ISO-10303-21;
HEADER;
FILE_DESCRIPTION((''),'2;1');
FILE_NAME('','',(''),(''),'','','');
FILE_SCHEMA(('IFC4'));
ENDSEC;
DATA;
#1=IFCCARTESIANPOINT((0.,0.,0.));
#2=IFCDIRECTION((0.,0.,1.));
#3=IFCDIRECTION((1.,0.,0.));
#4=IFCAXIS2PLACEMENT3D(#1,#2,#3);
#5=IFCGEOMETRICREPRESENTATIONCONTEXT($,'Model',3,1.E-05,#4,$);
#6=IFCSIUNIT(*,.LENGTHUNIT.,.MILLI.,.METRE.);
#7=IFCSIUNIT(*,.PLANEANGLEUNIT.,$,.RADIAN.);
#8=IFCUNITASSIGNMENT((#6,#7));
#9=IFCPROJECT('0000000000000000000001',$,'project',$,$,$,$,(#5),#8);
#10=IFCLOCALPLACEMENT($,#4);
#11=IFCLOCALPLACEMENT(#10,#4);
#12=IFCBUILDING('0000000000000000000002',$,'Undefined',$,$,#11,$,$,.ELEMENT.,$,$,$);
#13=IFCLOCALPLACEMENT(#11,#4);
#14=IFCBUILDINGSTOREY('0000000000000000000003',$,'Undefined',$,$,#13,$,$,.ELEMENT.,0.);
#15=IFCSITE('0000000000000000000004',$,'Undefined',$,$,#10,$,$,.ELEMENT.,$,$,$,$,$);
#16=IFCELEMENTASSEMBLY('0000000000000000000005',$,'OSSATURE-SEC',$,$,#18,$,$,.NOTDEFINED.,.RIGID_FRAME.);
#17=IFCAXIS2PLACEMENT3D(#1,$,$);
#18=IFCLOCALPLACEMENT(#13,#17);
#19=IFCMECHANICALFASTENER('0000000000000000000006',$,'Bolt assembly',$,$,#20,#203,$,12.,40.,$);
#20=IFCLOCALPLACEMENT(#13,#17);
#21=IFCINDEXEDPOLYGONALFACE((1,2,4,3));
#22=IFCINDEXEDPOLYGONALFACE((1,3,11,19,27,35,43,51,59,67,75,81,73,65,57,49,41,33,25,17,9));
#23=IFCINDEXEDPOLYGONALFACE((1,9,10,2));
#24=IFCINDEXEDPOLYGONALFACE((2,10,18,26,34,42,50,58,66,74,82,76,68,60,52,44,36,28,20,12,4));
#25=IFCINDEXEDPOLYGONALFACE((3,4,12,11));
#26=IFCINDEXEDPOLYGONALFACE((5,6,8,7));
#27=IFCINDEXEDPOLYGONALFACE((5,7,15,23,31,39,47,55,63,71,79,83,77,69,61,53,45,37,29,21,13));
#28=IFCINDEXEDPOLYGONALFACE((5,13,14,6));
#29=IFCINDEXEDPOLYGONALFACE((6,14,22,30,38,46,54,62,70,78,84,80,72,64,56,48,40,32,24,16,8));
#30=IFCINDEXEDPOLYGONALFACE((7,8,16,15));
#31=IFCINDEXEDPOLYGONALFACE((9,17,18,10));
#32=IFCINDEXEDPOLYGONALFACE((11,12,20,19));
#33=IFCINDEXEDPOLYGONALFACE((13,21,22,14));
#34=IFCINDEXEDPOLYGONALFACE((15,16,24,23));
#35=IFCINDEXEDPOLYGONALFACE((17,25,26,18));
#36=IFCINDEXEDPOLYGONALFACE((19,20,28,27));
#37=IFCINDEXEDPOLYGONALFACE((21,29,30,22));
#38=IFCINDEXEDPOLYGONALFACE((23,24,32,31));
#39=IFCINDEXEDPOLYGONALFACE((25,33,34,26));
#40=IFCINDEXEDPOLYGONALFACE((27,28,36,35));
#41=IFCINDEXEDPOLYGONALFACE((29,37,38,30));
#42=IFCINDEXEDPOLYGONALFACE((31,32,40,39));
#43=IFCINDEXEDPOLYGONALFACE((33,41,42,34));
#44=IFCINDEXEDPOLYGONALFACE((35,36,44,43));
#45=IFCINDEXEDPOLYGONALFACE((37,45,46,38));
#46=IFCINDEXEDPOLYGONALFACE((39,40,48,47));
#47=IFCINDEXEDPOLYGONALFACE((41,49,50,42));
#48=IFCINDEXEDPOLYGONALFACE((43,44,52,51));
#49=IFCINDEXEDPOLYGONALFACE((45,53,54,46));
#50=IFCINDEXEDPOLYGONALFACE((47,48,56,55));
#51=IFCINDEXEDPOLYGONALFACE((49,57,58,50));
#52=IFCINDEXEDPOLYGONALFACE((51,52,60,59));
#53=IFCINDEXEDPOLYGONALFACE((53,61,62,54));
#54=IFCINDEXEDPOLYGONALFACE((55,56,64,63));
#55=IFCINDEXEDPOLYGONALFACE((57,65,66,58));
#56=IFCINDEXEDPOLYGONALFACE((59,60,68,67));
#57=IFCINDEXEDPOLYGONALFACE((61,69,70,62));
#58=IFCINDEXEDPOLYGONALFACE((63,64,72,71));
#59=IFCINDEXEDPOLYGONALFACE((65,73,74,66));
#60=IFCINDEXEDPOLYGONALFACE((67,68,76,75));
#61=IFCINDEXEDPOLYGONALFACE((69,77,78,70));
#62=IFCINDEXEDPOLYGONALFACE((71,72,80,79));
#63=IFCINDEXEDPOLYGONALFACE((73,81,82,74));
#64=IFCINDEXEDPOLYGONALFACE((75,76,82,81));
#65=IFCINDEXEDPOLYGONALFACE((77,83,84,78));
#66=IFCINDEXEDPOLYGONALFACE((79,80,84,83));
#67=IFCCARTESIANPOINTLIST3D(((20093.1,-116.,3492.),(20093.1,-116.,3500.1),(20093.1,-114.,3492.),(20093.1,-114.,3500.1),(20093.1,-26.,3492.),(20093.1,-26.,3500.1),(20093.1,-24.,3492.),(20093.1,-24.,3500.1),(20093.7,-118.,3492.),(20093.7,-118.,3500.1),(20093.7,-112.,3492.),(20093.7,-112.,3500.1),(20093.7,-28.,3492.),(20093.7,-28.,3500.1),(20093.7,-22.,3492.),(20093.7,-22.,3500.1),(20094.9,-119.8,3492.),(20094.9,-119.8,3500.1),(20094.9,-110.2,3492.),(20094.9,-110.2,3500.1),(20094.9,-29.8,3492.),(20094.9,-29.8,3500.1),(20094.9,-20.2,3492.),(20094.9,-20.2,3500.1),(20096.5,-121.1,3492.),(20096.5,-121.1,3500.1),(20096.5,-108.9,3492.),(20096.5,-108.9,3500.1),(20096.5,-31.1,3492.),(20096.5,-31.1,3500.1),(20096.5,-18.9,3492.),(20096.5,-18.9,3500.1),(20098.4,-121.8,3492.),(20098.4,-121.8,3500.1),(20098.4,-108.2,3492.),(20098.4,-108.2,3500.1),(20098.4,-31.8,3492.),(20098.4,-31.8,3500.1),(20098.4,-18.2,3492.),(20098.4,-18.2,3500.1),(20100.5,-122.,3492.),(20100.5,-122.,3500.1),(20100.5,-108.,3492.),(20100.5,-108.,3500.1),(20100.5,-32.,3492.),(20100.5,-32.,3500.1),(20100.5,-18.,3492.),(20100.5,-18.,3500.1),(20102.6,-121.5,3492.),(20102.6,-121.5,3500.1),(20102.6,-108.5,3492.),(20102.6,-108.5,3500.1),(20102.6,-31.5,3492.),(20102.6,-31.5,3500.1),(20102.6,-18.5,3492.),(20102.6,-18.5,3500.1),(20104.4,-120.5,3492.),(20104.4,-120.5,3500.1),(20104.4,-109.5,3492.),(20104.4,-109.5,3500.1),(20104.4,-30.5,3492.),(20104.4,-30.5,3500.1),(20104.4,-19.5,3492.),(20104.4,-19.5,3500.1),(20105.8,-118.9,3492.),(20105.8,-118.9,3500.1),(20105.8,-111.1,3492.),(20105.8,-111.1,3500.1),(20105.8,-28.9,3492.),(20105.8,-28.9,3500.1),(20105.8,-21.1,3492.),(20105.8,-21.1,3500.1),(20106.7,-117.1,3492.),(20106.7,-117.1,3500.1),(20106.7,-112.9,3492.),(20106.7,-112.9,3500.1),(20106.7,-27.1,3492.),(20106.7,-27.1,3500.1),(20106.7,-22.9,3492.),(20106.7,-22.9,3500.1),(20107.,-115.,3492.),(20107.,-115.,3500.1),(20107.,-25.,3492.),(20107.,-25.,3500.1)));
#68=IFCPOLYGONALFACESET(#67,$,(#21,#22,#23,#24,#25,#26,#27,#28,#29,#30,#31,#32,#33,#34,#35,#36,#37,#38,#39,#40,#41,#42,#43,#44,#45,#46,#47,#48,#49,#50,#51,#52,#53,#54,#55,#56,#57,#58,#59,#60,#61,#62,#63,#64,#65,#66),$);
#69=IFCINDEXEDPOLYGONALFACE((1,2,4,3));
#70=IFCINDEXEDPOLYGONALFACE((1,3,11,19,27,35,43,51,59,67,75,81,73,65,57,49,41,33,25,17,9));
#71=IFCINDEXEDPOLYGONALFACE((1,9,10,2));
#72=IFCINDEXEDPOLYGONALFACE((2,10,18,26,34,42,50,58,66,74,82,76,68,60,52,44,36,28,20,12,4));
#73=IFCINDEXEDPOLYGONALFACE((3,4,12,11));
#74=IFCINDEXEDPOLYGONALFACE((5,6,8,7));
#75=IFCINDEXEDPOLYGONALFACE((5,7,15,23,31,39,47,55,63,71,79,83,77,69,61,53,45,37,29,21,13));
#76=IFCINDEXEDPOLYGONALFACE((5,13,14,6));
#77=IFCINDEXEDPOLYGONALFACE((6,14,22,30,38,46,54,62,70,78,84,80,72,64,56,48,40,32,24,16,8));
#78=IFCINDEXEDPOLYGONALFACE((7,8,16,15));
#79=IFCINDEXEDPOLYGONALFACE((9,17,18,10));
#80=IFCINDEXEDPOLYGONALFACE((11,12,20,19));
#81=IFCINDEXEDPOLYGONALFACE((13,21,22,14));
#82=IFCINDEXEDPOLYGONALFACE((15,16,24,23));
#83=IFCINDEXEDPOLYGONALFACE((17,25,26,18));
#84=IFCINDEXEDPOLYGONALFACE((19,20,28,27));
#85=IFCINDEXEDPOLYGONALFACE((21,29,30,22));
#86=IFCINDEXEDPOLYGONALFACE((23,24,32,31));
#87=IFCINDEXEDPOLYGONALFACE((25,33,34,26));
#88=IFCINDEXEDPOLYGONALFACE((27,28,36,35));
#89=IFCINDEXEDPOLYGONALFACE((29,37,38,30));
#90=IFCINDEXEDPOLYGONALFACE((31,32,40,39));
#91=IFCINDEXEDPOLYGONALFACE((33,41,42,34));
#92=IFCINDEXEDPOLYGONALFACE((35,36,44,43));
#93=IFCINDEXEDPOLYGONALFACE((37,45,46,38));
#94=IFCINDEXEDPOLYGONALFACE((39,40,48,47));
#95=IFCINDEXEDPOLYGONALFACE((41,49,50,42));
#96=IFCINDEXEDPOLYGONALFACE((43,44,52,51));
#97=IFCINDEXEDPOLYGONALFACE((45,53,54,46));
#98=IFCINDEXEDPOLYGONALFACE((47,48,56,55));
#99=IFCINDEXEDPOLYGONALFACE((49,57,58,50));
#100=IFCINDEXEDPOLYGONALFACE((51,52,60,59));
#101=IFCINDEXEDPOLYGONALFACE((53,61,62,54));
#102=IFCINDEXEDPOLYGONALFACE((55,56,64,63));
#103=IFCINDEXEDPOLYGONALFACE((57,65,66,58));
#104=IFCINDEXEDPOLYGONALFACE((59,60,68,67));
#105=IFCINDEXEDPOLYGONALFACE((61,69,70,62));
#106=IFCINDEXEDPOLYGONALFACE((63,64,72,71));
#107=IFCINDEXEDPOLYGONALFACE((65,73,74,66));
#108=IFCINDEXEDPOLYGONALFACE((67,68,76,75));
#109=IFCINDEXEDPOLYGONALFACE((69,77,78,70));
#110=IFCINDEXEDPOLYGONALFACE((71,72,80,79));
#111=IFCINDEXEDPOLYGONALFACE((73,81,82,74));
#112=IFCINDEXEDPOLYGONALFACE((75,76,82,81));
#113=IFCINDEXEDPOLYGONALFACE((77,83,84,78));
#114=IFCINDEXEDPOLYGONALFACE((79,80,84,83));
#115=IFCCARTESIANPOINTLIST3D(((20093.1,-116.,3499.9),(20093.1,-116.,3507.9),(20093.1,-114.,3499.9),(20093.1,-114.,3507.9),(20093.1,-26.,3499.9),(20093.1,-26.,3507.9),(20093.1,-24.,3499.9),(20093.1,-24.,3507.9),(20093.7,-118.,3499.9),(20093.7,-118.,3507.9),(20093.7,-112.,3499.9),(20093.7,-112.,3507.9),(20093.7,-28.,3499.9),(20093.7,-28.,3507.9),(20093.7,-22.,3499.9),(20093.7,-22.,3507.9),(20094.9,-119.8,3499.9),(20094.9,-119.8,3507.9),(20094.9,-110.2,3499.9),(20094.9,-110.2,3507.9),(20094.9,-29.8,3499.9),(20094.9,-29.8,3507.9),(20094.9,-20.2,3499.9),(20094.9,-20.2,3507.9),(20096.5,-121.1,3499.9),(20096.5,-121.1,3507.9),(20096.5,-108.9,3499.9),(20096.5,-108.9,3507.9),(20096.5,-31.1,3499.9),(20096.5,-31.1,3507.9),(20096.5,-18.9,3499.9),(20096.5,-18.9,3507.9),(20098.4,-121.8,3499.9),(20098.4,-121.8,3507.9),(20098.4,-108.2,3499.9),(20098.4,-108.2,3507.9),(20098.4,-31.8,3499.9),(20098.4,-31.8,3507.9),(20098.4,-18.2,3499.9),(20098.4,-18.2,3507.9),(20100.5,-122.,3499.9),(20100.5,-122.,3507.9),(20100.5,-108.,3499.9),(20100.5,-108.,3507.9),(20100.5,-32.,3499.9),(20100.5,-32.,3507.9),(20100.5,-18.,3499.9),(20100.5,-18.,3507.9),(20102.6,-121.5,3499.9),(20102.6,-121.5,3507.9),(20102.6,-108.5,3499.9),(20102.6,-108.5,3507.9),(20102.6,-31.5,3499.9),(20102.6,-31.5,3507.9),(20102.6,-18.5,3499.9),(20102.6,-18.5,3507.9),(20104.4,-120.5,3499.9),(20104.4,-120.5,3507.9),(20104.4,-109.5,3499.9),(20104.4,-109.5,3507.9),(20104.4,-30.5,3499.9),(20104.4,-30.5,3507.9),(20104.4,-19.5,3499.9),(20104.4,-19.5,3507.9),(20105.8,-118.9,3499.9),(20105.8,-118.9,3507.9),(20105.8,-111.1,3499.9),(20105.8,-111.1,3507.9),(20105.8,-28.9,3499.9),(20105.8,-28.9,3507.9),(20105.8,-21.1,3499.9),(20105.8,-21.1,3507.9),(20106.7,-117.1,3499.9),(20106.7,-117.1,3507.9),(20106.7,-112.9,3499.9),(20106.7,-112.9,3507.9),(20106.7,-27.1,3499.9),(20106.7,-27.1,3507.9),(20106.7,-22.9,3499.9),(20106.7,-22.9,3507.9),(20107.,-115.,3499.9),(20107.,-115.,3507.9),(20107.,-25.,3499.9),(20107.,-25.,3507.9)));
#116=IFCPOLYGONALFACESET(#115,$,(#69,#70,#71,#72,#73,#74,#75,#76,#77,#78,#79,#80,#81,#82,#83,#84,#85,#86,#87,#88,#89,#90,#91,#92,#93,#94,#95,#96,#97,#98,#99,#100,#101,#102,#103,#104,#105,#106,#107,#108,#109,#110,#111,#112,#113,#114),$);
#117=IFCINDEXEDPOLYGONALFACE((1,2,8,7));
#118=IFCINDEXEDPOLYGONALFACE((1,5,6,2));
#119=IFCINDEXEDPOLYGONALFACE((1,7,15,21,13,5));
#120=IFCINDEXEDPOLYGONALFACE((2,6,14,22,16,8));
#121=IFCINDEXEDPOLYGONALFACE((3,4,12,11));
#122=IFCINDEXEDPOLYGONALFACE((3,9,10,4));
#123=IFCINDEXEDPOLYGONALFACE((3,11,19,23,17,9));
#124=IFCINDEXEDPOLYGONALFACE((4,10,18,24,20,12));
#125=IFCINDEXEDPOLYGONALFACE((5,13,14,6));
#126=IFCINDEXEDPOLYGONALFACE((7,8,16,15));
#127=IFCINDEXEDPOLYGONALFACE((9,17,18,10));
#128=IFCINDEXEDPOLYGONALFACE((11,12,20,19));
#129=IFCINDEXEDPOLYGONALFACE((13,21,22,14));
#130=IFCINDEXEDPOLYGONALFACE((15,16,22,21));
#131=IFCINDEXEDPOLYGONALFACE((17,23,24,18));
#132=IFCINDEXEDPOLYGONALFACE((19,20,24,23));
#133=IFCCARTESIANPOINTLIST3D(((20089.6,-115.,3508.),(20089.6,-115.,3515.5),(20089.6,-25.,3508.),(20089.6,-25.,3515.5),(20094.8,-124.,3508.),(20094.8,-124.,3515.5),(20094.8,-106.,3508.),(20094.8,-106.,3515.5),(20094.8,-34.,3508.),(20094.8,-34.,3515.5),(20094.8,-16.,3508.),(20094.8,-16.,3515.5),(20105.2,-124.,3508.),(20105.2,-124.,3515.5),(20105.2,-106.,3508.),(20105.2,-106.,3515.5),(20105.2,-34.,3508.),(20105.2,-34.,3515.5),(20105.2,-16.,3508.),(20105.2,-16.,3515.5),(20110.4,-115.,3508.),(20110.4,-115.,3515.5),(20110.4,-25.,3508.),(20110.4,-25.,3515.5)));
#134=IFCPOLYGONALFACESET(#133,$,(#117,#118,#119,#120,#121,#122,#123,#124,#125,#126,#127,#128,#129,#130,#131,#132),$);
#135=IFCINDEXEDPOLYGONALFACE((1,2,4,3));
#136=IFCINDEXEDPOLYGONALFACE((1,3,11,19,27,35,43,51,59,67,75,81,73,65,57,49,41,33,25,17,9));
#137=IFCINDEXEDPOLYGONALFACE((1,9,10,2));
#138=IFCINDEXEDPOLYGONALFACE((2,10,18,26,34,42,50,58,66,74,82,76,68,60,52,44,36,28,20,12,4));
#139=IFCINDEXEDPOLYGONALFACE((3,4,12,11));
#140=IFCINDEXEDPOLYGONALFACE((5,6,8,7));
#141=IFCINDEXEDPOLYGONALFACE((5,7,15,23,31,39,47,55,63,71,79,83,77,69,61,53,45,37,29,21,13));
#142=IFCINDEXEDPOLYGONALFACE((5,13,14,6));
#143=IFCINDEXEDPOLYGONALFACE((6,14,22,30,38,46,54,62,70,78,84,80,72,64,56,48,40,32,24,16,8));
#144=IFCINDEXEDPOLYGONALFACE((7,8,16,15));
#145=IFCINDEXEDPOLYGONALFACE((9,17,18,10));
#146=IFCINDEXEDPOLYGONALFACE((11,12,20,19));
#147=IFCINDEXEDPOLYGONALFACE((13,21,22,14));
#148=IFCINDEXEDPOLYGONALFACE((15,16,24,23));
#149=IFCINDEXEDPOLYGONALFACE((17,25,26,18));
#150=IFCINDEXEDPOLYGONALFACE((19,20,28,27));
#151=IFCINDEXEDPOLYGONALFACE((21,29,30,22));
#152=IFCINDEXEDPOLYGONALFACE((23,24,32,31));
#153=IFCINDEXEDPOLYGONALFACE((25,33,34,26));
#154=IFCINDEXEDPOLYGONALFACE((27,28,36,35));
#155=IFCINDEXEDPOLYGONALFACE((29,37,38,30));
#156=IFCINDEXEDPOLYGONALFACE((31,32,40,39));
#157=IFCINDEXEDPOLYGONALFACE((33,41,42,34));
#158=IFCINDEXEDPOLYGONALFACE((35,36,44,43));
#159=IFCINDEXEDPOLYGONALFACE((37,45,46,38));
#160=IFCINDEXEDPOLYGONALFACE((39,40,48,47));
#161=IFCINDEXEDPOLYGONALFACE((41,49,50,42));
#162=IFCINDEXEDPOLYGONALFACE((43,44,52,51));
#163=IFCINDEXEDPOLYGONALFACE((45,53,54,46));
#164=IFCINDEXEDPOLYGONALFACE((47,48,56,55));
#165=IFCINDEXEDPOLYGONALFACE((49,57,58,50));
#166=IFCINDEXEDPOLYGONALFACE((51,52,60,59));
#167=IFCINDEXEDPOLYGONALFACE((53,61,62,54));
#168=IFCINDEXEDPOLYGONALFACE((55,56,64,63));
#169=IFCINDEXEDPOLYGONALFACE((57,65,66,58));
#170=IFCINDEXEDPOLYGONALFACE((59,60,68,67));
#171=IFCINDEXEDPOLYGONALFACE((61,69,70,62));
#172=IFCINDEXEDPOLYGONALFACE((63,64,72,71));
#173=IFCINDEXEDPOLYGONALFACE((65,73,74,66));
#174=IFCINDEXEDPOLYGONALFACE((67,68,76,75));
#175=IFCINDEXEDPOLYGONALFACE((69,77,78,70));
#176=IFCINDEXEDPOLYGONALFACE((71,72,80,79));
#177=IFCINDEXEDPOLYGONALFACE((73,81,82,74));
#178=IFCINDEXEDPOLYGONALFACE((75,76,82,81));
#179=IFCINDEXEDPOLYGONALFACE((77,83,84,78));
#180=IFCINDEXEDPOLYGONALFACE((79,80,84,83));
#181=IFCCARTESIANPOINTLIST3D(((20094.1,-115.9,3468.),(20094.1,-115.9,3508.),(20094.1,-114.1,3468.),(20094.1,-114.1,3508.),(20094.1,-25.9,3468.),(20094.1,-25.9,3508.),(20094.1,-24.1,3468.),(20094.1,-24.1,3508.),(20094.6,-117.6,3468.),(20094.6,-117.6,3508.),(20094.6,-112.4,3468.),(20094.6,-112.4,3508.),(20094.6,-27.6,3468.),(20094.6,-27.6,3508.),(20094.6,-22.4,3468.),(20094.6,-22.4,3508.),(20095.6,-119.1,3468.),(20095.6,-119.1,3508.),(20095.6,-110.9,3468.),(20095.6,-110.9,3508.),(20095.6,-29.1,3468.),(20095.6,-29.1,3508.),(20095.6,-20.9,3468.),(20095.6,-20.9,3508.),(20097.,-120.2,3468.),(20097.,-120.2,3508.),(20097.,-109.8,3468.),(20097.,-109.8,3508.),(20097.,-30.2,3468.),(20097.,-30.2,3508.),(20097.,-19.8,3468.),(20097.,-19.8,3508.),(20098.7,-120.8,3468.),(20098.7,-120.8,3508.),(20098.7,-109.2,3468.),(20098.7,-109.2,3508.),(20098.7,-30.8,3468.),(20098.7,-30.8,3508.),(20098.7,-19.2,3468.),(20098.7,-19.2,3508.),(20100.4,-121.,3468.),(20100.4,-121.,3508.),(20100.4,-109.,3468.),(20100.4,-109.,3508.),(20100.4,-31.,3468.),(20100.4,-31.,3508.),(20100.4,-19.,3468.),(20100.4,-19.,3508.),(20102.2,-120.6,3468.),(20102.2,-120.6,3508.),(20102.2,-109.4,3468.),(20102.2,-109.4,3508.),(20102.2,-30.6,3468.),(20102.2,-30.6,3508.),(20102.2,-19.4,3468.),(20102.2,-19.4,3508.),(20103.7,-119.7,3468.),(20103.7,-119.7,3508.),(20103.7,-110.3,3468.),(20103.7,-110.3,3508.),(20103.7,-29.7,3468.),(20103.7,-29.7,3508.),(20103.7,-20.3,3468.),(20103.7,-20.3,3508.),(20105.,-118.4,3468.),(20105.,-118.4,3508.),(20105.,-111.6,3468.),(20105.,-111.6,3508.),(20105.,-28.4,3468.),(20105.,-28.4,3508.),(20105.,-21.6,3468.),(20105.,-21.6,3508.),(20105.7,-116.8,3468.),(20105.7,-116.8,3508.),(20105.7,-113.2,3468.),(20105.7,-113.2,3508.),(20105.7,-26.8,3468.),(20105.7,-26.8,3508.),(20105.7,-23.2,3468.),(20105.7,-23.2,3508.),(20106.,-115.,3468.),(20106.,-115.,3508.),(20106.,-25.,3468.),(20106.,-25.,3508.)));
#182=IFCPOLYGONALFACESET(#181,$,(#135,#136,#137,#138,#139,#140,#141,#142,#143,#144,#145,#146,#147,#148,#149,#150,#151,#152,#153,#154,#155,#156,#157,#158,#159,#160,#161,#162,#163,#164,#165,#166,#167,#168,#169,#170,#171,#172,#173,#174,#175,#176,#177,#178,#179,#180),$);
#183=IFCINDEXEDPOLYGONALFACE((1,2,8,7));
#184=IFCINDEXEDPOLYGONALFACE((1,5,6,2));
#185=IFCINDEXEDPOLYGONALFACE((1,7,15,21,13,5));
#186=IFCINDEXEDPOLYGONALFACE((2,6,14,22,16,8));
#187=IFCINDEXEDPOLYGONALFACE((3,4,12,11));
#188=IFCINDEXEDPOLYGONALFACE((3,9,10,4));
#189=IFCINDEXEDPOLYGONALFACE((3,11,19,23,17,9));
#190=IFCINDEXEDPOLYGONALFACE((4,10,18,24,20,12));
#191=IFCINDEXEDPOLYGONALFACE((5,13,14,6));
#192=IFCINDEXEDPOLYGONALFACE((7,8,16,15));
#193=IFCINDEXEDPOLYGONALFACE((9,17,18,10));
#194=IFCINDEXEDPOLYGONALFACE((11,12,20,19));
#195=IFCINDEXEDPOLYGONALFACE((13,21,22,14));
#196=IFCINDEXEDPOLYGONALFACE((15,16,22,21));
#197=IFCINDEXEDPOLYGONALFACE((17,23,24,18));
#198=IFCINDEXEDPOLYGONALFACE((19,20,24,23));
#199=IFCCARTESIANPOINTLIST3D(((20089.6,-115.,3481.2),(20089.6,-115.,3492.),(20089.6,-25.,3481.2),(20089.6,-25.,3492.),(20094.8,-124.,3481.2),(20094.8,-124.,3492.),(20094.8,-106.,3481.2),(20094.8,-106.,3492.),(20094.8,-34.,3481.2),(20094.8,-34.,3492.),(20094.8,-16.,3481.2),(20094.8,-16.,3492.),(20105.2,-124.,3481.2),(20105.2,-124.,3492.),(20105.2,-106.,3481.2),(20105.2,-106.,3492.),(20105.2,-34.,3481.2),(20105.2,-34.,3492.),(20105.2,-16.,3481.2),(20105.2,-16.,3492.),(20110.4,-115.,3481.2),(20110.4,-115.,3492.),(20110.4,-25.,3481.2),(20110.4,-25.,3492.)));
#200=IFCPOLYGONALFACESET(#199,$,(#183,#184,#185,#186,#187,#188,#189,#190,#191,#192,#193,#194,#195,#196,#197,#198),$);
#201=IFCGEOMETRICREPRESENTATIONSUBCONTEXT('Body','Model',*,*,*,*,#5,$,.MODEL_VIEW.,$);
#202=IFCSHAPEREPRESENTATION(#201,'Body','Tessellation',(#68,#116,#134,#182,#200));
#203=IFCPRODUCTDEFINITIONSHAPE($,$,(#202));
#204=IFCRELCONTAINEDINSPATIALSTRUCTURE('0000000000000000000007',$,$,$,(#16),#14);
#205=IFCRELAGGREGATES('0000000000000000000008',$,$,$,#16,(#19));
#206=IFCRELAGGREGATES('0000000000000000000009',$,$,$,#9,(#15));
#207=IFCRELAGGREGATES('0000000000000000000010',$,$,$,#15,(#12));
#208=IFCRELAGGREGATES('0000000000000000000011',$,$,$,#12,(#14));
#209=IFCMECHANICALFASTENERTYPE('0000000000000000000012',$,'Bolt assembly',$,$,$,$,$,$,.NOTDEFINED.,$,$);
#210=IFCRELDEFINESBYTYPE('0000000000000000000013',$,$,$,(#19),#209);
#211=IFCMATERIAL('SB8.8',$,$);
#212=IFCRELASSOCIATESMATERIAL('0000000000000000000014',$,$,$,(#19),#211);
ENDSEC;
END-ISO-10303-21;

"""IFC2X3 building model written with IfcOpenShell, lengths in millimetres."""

from ifc_helpers import new_model, si_unit, frame, origin_with_axes, origin_2d_with_axis, place, context, subcontext, project, spatial, polyline, circle, outline, extrude, source, transform, mapped, material, type_object, element, aggregate, save


model = new_model("IFC2X3")

# Units and contexts
model_context = context("Model", 3, precision=1e-05, world=origin_with_axes())
body_context = subcontext(model_context, "Body", "Model", "MODEL_VIEW")
ifc_project = project(units=[si_unit("LENGTHUNIT", "METRE", prefix="MILLI"), si_unit("PLANEANGLEUNIT", "RADIAN")], contexts=[model_context])

# Site, building, storey
site_placement = place(None, origin_with_axes())
site = spatial("IfcSite", under=ifc_project, at=site_placement, Name="Undefined", CompositionType="ELEMENT")
building_placement = place(site_placement, origin_with_axes())
building = spatial("IfcBuilding", under=site, at=building_placement, Name="Undefined", CompositionType="ELEMENT")
storey_placement = place(building_placement, origin_with_axes())
storey = spatial("IfcBuildingStorey", under=building, at=storey_placement, Name="Undefined", CompositionType="ELEMENT", Elevation=0.0)

# Element assembly
assembly_1_placement = place(storey_placement, origin_with_axes())
assembly_1 = element("IfcElementAssembly", 1, at=assembly_1_placement, inside=storey, Name="OSSATURE-SEC", AssemblyPlace="NOTDEFINED", PredefinedType="RIGID_FRAME")

# Mechanical fastener
ifc_material_1 = material(Name="SB8.8")
mechanical_fastener_type = type_object("IfcMechanicalFastenerType", Name="Bolt assembly")
shared_shape_1 = source(origin_with_axes(), body_context, "Body", "SweptSolid", [
    extrude(circle(Radius=7.0, at=origin_2d_with_axis()), frame((0.0, -0.1, 0.0), z_axis=(0.0, 1.0, 0.0), x_axis=(1.0, 0.0, 0.0)), (0.0, 0.0, 1.0), 8.1),
    extrude(circle(Radius=7.0, at=origin_2d_with_axis()), frame((0.0, -7.9, 0.0), z_axis=(0.0, 1.0, 0.0), x_axis=(1.0, 0.0, 0.0)), (0.0, 0.0, 1.0), 8.0),
    extrude(outline(polyline([(10.4, 0.0), (5.2, 9.0), (-5.2, 9.0), (-10.4, 0.0), (-5.2, -9.0), (5.2, -9.0), (10.4, 0.0)])), frame((0.0, -15.5, 0.0), z_axis=(0.0, 1.0, 0.0), x_axis=(1.0, 0.0, 0.0)), (0.0, 0.0, 1.0), 7.5),
    extrude(circle(Radius=6.0, at=origin_2d_with_axis()), frame((0.0, -8.0, 0.0), z_axis=(0.0, 1.0, 0.0), x_axis=(1.0, 0.0, 0.0)), (0.0, 0.0, 1.0), 40.0),
    extrude(outline(polyline([(10.4, 0.0), (5.2, 9.0), (-5.2, 9.0), (-10.4, 0.0), (-5.2, -9.0), (5.2, -9.0), (10.4, 0.0)])), frame((0.0, 8.0, 0.0), z_axis=(0.0, 1.0, 0.0), x_axis=(1.0, 0.0, 0.0)), (0.0, 0.0, 1.0), 10.8),
])
mechanical_fastener_1_placement = place(assembly_1_placement, frame((20100.0, -70.0, 3500.0), z_axis=(0.0, 1.0, 0.0), x_axis=(1.0, 0.0, 0.0)))
mechanical_fastener_1 = element("IfcMechanicalFastener", 2, at=mechanical_fastener_1_placement, type_object=mechanical_fastener_type, material=ifc_material_1, Name="Bolt assembly", NominalDiameter=12.0, NominalLength=40.0, context=body_context, shape_type="MappedRepresentation", body=[
    mapped(shared_shape_1, transform((0.0, 0.0, -45.0))),
    mapped(shared_shape_1, transform((0.0, 0.0, 45.0))),
])
aggregate(assembly_1, [mechanical_fastener_1])

save(model, "model.ifc")
